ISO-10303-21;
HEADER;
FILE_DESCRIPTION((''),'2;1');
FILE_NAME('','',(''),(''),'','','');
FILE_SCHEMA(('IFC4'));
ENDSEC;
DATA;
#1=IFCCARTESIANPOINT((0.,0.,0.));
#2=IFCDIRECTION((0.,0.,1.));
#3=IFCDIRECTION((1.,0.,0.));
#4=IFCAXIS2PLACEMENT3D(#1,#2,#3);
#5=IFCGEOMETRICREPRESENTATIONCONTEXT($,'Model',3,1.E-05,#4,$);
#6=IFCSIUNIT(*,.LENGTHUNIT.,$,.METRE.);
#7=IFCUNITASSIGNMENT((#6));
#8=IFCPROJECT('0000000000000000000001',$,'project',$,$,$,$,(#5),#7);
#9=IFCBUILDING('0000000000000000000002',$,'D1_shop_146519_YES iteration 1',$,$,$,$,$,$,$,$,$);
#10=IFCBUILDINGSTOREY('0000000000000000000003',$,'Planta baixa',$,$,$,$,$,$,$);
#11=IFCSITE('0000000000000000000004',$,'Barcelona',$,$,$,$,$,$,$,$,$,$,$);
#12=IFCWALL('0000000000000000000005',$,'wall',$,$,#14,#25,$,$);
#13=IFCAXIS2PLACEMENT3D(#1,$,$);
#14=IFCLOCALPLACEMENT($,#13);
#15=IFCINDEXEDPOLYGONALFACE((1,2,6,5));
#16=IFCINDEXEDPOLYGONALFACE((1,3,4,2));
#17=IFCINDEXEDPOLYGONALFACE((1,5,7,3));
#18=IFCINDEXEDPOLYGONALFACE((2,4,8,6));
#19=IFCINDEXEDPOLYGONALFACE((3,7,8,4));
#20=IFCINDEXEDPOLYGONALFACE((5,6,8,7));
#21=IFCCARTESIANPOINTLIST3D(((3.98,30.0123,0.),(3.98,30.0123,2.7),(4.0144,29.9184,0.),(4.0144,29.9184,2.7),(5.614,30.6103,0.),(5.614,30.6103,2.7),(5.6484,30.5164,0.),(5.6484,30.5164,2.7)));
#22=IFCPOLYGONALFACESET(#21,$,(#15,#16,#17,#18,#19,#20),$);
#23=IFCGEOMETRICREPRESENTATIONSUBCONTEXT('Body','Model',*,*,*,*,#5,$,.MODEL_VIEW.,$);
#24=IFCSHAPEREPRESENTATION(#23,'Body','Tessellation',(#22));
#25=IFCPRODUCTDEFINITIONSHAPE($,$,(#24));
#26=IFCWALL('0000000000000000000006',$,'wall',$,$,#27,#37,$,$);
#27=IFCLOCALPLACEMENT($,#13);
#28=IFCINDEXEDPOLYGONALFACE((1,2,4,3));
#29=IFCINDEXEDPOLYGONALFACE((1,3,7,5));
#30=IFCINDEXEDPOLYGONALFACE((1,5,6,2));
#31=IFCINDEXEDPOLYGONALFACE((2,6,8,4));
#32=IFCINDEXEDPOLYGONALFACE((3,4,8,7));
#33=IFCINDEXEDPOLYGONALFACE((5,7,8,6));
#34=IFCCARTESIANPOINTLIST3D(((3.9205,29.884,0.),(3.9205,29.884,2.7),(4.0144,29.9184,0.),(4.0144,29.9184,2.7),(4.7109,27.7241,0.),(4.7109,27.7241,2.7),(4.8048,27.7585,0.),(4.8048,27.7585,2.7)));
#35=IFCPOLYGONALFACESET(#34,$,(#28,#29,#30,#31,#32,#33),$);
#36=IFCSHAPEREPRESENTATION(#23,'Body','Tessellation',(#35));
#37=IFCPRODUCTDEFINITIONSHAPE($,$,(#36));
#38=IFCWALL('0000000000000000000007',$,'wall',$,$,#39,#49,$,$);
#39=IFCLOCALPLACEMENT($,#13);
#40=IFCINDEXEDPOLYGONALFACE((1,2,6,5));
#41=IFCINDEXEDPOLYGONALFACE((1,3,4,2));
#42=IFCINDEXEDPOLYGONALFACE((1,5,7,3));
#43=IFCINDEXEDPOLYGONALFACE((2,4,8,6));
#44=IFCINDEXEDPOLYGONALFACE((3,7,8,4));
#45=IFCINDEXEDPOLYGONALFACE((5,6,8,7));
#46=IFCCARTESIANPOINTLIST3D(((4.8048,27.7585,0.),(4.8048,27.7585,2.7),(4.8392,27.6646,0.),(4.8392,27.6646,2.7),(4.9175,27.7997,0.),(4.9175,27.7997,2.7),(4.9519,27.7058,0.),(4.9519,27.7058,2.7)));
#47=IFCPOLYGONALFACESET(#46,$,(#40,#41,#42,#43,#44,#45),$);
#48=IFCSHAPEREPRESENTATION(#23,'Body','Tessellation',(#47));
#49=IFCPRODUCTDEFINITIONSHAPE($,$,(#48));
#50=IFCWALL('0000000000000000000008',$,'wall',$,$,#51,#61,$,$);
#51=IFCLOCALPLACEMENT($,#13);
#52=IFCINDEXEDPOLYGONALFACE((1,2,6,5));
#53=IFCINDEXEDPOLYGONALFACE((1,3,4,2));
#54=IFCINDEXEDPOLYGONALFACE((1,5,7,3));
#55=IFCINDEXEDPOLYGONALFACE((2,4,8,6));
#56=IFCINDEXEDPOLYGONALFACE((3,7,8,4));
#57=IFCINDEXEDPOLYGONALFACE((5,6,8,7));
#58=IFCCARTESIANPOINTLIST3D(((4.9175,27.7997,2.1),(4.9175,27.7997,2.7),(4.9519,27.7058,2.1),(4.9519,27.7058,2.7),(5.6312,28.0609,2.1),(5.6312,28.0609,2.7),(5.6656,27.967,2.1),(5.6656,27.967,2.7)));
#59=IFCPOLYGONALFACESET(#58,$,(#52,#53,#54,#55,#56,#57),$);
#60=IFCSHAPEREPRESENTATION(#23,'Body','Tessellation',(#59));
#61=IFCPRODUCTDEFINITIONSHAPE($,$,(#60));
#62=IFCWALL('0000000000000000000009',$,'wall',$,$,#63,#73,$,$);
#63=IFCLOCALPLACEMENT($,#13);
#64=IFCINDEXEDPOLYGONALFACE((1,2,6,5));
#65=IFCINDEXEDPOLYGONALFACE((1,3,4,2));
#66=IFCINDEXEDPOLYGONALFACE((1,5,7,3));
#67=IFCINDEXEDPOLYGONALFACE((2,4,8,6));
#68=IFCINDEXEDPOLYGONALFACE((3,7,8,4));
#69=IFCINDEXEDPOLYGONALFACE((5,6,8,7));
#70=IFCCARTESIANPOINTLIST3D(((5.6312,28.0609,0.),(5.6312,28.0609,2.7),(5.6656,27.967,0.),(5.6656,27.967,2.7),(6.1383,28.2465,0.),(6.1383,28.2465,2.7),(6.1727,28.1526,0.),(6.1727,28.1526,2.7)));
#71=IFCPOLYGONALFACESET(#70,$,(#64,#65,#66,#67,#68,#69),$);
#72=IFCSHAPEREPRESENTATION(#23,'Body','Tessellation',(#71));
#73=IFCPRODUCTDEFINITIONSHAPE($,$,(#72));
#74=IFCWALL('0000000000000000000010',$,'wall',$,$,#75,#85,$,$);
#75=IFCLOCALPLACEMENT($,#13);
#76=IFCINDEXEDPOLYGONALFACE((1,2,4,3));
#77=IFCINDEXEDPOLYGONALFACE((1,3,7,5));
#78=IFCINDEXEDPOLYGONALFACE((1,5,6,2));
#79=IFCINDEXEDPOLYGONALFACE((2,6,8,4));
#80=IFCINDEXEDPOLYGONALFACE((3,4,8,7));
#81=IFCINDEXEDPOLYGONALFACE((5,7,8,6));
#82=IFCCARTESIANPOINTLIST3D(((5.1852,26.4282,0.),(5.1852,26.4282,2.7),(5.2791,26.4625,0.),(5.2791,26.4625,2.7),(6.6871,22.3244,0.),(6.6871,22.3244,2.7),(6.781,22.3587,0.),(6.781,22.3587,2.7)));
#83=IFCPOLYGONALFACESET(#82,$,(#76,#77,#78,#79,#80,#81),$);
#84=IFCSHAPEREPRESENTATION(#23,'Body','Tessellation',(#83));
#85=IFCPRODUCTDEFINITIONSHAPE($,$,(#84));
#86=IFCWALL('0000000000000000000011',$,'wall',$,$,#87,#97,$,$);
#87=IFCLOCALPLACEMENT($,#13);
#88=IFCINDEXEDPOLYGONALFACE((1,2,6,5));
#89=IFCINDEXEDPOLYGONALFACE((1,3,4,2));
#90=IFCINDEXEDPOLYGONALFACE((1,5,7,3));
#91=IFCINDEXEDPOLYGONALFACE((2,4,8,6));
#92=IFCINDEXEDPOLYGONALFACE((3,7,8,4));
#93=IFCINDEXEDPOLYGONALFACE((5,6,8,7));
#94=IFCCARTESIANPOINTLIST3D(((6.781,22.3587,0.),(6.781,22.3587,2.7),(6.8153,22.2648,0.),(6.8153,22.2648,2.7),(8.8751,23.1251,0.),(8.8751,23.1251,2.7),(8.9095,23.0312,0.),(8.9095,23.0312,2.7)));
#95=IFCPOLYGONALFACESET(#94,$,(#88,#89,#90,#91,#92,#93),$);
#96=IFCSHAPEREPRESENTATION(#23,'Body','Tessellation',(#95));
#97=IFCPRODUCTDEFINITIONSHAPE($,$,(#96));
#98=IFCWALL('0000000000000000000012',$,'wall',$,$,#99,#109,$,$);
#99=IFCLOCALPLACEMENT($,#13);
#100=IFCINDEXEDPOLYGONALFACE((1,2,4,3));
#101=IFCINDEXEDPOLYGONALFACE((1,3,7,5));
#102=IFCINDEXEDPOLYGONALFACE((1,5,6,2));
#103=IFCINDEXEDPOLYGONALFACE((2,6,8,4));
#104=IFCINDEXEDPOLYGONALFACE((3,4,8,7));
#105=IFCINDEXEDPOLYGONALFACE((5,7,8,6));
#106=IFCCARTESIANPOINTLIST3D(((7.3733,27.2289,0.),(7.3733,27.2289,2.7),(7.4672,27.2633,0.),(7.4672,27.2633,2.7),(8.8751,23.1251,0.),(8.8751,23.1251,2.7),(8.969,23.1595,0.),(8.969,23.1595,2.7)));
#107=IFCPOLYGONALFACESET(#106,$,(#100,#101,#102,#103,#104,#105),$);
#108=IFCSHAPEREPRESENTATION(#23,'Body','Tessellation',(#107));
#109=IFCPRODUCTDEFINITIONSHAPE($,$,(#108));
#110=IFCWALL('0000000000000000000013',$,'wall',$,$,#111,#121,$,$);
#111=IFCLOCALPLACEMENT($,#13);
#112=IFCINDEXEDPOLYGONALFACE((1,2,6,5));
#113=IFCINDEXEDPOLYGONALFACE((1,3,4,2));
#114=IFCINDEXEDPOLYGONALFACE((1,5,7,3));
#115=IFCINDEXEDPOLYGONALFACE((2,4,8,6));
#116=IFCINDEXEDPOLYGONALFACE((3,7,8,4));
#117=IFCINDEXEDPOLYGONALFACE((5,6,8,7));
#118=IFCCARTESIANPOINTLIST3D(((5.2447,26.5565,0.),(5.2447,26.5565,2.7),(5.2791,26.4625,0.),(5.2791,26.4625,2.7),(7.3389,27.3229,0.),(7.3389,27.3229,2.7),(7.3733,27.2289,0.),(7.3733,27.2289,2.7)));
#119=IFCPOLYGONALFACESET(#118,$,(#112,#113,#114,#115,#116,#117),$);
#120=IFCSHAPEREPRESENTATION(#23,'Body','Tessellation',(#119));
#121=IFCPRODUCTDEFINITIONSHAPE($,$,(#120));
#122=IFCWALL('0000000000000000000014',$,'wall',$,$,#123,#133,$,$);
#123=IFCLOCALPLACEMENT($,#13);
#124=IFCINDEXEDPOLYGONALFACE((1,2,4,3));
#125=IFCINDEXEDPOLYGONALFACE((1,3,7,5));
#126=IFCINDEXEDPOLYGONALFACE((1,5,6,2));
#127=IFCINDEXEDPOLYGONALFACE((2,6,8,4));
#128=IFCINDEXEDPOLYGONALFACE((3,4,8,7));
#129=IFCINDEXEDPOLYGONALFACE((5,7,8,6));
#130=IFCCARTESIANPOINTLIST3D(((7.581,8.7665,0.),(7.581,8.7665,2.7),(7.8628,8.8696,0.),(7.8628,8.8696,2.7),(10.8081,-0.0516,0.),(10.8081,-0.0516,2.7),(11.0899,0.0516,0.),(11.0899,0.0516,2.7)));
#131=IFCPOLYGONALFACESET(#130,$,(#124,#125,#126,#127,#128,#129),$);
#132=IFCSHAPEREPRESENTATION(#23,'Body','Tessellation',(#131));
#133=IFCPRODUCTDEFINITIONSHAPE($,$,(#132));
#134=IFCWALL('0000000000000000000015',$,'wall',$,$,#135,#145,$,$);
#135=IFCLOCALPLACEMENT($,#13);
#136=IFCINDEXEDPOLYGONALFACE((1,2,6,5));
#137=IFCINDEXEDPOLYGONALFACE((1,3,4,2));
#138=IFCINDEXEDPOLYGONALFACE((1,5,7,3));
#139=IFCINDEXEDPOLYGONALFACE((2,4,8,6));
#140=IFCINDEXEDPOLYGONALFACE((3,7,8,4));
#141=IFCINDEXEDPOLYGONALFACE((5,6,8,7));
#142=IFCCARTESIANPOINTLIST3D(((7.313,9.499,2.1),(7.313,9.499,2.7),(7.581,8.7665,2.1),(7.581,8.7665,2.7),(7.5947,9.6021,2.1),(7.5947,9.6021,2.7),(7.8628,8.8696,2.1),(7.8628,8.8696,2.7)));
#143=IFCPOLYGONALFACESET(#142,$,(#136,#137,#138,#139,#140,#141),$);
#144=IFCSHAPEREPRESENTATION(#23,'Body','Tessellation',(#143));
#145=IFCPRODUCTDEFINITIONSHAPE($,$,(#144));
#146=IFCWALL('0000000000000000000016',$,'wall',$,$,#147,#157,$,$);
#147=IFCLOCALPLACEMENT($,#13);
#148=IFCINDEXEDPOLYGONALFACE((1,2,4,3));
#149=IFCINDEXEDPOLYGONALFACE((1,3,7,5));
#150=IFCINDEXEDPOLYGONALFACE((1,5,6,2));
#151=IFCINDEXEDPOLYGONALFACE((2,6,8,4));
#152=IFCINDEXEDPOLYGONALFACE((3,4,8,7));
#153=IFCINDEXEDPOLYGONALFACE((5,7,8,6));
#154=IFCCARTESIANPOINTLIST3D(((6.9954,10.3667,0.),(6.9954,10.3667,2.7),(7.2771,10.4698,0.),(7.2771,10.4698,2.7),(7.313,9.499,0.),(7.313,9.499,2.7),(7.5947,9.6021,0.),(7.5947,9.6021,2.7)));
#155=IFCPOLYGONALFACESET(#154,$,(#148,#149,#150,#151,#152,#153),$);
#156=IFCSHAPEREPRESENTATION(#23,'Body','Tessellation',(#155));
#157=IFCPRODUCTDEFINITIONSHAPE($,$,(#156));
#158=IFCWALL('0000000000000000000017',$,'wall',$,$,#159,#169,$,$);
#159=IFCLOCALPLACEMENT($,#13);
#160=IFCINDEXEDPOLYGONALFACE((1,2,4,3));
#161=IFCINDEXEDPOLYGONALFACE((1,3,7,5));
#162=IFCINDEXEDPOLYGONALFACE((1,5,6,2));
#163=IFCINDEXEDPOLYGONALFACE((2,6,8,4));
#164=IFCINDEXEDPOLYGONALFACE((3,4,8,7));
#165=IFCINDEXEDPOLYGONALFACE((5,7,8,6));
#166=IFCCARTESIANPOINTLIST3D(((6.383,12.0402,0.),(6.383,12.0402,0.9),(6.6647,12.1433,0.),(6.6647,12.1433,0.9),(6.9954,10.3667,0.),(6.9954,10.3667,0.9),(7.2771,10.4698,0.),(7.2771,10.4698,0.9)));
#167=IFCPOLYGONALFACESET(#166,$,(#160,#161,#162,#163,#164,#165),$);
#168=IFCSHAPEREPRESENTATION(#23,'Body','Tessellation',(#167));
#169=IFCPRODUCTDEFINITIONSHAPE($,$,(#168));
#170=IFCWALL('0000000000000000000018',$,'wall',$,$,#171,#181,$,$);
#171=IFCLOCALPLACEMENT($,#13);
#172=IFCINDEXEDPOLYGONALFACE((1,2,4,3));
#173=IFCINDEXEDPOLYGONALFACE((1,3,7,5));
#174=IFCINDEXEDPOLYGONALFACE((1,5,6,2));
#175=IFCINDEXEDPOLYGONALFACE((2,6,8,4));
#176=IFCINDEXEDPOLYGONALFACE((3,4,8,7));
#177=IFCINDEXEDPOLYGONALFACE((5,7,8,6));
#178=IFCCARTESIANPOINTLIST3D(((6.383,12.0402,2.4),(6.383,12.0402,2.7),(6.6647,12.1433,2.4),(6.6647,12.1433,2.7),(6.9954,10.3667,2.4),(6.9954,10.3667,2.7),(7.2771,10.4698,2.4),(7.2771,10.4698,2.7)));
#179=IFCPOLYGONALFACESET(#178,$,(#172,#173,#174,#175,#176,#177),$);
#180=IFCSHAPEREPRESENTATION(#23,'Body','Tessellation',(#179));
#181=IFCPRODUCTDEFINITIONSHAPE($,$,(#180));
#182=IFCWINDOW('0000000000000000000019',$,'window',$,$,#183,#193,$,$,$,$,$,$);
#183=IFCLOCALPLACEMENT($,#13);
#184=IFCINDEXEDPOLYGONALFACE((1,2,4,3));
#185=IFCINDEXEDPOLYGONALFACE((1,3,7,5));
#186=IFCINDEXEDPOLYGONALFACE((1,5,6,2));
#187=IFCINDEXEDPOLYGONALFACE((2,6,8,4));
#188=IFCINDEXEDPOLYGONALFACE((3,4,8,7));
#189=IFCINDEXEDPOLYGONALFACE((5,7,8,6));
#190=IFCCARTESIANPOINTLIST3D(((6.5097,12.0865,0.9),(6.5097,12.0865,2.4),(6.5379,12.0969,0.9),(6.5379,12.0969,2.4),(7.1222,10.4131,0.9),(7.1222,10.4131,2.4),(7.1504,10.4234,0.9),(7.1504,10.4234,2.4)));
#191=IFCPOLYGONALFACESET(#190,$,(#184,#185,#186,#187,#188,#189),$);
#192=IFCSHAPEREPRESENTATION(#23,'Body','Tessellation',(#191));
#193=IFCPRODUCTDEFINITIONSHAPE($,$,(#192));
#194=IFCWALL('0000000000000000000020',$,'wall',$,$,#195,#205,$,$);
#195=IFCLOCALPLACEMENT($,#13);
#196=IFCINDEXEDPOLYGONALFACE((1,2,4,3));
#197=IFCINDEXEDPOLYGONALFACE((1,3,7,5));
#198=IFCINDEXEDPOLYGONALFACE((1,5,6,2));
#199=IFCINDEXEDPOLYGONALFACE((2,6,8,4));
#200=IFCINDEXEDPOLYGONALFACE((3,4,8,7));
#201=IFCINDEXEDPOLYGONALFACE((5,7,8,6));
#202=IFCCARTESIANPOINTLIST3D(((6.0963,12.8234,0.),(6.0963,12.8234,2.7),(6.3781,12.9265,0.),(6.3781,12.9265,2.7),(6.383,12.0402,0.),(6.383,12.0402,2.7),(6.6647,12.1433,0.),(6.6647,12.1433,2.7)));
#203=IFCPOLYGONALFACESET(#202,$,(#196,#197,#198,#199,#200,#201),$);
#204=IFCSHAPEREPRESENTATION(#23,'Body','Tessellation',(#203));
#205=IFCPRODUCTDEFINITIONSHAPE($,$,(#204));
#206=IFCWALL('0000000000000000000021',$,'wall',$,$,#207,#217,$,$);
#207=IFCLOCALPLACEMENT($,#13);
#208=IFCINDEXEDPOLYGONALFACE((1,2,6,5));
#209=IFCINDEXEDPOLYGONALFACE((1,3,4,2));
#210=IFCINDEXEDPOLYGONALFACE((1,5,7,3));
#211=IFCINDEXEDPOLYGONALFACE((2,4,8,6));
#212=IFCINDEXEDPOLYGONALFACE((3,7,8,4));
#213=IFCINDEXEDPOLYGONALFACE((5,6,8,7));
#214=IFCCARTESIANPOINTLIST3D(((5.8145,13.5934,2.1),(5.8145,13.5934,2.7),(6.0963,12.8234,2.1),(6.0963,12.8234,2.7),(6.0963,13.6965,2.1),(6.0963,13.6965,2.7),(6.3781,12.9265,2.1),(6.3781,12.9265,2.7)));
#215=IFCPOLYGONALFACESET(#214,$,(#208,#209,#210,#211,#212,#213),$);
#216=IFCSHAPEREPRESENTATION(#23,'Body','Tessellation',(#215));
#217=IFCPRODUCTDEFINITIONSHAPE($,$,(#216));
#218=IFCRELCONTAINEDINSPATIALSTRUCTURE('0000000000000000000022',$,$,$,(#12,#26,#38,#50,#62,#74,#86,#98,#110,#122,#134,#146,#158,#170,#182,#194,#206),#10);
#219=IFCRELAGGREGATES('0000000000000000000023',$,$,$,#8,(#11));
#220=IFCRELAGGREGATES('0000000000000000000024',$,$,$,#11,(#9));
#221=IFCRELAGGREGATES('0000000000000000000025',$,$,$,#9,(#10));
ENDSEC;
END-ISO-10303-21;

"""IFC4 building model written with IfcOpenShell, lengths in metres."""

from ifc_helpers import new_model, si_unit, frame, origin, origin_with_axes, place, context, subcontext, project, spatial, polyline, outline, extrude, element, save


model = new_model("IFC4")

# Units and contexts
model_context = context("Model", 3, precision=1e-05, world=origin_with_axes())
body_context = subcontext(model_context, "Body", "Model", "MODEL_VIEW")
ifc_project = project(units=[si_unit("LENGTHUNIT", "METRE")], contexts=[model_context])

# Site, building, storey
site = spatial("IfcSite", under=ifc_project, Name="Barcelona")
building = spatial("IfcBuilding", under=site, Name="D1_shop_146519_YES iteration 1")
storey = spatial("IfcBuildingStorey", under=building, Name="Planta baixa")

# Walls
wall_1_placement = place(None, origin_with_axes())
element("IfcWall", 1, at=wall_1_placement, inside=storey, Name="wall", context=body_context, shape_type="SweptSolid", body=[
    extrude(outline(polyline([(5.6484, 30.5164), (4.0144, 29.9184), (3.98, 30.0123), (5.614, 30.6103), (5.6484, 30.5164)])), origin(), (0.0, 0.0, 1.0), 2.7),
])
wall_2_placement = place(None, origin_with_axes())
element("IfcWall", 2, at=wall_2_placement, inside=storey, Name="wall", context=body_context, shape_type="SweptSolid", body=[
    extrude(outline(polyline([(4.0144, 29.9184), (4.8048, 27.7585), (4.7109, 27.7241), (3.9205, 29.884), (4.0144, 29.9184)])), origin(), (0.0, 0.0, 1.0), 2.7),
])
wall_3_placement = place(None, origin_with_axes())
element("IfcWall", 3, at=wall_3_placement, inside=storey, Name="wall", context=body_context, shape_type="SweptSolid", body=[
    extrude(outline(polyline([(4.8048, 27.7585), (4.9175, 27.7997), (4.9519, 27.7058), (4.8392, 27.6646), (4.8048, 27.7585)])), origin(), (0.0, 0.0, 1.0), 2.7),
])
wall_4_placement = place(None, origin_with_axes())
element("IfcWall", 4, at=wall_4_placement, inside=storey, Name="wall", context=body_context, shape_type="SweptSolid", body=[
    extrude(outline(polyline([(4.9175, 27.7997), (5.6312, 28.0609), (5.6656, 27.967), (4.9519, 27.7058), (4.9175, 27.7997)])), frame((0.0, 0.0, 2.1)), (0.0, 0.0, 1.0), 0.6),
])
wall_5_placement = place(None, origin_with_axes())
element("IfcWall", 5, at=wall_5_placement, inside=storey, Name="wall", context=body_context, shape_type="SweptSolid", body=[
    extrude(outline(polyline([(5.6312, 28.0609), (6.1383, 28.2465), (6.1727, 28.1526), (5.6656, 27.967), (5.6312, 28.0609)])), origin(), (0.0, 0.0, 1.0), 2.7),
])
wall_6_placement = place(None, origin_with_axes())
element("IfcWall", 6, at=wall_6_placement, inside=storey, Name="wall", context=body_context, shape_type="SweptSolid", body=[
    extrude(outline(polyline([(5.2791, 26.4625), (6.781, 22.3587), (6.6871, 22.3244), (5.1852, 26.4282), (5.2791, 26.4625)])), origin(), (0.0, 0.0, 1.0), 2.7),
])
wall_7_placement = place(None, origin_with_axes())
element("IfcWall", 7, at=wall_7_placement, inside=storey, Name="wall", context=body_context, shape_type="SweptSolid", body=[
    extrude(outline(polyline([(6.781, 22.3587), (8.8751, 23.1251), (8.9095, 23.0312), (6.8153, 22.2648), (6.781, 22.3587)])), origin(), (0.0, 0.0, 1.0), 2.7),
])
wall_8_placement = place(None, origin_with_axes())
element("IfcWall", 8, at=wall_8_placement, inside=storey, Name="wall", context=body_context, shape_type="SweptSolid", body=[
    extrude(outline(polyline([(8.8751, 23.1251), (7.3733, 27.2289), (7.4672, 27.2633), (8.969, 23.1595), (8.8751, 23.1251)])), origin(), (0.0, 0.0, 1.0), 2.7),
])
wall_9_placement = place(None, origin_with_axes())
element("IfcWall", 9, at=wall_9_placement, inside=storey, Name="wall", context=body_context, shape_type="SweptSolid", body=[
    extrude(outline(polyline([(7.3733, 27.2289), (5.2791, 26.4625), (5.2447, 26.5565), (7.3389, 27.3229), (7.3733, 27.2289)])), origin(), (0.0, 0.0, 1.0), 2.7),
])
wall_10_placement = place(None, origin_with_axes())
element("IfcWall", 10, at=wall_10_placement, inside=storey, Name="wall", context=body_context, shape_type="SweptSolid", body=[
    extrude(outline(polyline([(10.8081, -0.0516), (7.581, 8.7665), (7.8628, 8.8696), (11.0899, 0.0516), (10.8081, -0.0516)])), origin(), (0.0, 0.0, 1.0), 2.7),
])
wall_11_placement = place(None, origin_with_axes())
element("IfcWall", 11, at=wall_11_placement, inside=storey, Name="wall", context=body_context, shape_type="SweptSolid", body=[
    extrude(outline(polyline([(7.581, 8.7665), (7.313, 9.499), (7.5947, 9.6021), (7.8628, 8.8696), (7.581, 8.7665)])), frame((0.0, 0.0, 2.1)), (0.0, 0.0, 1.0), 0.6),
])
wall_12_placement = place(None, origin_with_axes())
element("IfcWall", 12, at=wall_12_placement, inside=storey, Name="wall", context=body_context, shape_type="SweptSolid", body=[
    extrude(outline(polyline([(7.313, 9.499), (6.9954, 10.3667), (7.2771, 10.4698), (7.5947, 9.6021), (7.313, 9.499)])), origin(), (0.0, 0.0, 1.0), 2.7),
])
wall_13_placement = place(None, origin_with_axes())
element("IfcWall", 13, at=wall_13_placement, inside=storey, Name="wall", context=body_context, shape_type="SweptSolid", body=[
    extrude(outline(polyline([(6.9954, 10.3667), (6.383, 12.0402), (6.6647, 12.1433), (7.2771, 10.4698), (6.9954, 10.3667)])), origin(), (0.0, 0.0, 1.0), 0.9),
])
wall_14_placement = place(None, origin_with_axes())
element("IfcWall", 14, at=wall_14_placement, inside=storey, Name="wall", context=body_context, shape_type="SweptSolid", body=[
    extrude(outline(polyline([(6.9954, 10.3667), (6.383, 12.0402), (6.6647, 12.1433), (7.2771, 10.4698), (6.9954, 10.3667)])), frame((0.0, 0.0, 2.4)), (0.0, 0.0, 1.0), 0.3),
])

# Window
window_1_placement = place(None, origin_with_axes())
element("IfcWindow", 15, at=window_1_placement, inside=storey, Name="window", context=body_context, shape_type="SweptSolid", body=[
    extrude(outline(polyline([(7.1222, 10.4131), (6.5097, 12.0865), (6.5379, 12.0969), (7.1504, 10.4234), (7.1222, 10.4131)])), frame((0.0, 0.0, 0.9)), (0.0, 0.0, 1.0), 1.5),
])

# Walls
wall_15_placement = place(None, origin_with_axes())
element("IfcWall", 16, at=wall_15_placement, inside=storey, Name="wall", context=body_context, shape_type="SweptSolid", body=[
    extrude(outline(polyline([(6.383, 12.0402), (6.0963, 12.8234), (6.3781, 12.9265), (6.6647, 12.1433), (6.383, 12.0402)])), origin(), (0.0, 0.0, 1.0), 2.7),
])
wall_16_placement = place(None, origin_with_axes())
element("IfcWall", 17, at=wall_16_placement, inside=storey, Name="wall", context=body_context, shape_type="SweptSolid", body=[
    extrude(outline(polyline([(6.0963, 12.8234), (5.8145, 13.5934), (6.0963, 13.6965), (6.3781, 12.9265), (6.0963, 12.8234)])), frame((0.0, 0.0, 2.1)), (0.0, 0.0, 1.0), 0.6),
])

save(model, "model.ifc")
